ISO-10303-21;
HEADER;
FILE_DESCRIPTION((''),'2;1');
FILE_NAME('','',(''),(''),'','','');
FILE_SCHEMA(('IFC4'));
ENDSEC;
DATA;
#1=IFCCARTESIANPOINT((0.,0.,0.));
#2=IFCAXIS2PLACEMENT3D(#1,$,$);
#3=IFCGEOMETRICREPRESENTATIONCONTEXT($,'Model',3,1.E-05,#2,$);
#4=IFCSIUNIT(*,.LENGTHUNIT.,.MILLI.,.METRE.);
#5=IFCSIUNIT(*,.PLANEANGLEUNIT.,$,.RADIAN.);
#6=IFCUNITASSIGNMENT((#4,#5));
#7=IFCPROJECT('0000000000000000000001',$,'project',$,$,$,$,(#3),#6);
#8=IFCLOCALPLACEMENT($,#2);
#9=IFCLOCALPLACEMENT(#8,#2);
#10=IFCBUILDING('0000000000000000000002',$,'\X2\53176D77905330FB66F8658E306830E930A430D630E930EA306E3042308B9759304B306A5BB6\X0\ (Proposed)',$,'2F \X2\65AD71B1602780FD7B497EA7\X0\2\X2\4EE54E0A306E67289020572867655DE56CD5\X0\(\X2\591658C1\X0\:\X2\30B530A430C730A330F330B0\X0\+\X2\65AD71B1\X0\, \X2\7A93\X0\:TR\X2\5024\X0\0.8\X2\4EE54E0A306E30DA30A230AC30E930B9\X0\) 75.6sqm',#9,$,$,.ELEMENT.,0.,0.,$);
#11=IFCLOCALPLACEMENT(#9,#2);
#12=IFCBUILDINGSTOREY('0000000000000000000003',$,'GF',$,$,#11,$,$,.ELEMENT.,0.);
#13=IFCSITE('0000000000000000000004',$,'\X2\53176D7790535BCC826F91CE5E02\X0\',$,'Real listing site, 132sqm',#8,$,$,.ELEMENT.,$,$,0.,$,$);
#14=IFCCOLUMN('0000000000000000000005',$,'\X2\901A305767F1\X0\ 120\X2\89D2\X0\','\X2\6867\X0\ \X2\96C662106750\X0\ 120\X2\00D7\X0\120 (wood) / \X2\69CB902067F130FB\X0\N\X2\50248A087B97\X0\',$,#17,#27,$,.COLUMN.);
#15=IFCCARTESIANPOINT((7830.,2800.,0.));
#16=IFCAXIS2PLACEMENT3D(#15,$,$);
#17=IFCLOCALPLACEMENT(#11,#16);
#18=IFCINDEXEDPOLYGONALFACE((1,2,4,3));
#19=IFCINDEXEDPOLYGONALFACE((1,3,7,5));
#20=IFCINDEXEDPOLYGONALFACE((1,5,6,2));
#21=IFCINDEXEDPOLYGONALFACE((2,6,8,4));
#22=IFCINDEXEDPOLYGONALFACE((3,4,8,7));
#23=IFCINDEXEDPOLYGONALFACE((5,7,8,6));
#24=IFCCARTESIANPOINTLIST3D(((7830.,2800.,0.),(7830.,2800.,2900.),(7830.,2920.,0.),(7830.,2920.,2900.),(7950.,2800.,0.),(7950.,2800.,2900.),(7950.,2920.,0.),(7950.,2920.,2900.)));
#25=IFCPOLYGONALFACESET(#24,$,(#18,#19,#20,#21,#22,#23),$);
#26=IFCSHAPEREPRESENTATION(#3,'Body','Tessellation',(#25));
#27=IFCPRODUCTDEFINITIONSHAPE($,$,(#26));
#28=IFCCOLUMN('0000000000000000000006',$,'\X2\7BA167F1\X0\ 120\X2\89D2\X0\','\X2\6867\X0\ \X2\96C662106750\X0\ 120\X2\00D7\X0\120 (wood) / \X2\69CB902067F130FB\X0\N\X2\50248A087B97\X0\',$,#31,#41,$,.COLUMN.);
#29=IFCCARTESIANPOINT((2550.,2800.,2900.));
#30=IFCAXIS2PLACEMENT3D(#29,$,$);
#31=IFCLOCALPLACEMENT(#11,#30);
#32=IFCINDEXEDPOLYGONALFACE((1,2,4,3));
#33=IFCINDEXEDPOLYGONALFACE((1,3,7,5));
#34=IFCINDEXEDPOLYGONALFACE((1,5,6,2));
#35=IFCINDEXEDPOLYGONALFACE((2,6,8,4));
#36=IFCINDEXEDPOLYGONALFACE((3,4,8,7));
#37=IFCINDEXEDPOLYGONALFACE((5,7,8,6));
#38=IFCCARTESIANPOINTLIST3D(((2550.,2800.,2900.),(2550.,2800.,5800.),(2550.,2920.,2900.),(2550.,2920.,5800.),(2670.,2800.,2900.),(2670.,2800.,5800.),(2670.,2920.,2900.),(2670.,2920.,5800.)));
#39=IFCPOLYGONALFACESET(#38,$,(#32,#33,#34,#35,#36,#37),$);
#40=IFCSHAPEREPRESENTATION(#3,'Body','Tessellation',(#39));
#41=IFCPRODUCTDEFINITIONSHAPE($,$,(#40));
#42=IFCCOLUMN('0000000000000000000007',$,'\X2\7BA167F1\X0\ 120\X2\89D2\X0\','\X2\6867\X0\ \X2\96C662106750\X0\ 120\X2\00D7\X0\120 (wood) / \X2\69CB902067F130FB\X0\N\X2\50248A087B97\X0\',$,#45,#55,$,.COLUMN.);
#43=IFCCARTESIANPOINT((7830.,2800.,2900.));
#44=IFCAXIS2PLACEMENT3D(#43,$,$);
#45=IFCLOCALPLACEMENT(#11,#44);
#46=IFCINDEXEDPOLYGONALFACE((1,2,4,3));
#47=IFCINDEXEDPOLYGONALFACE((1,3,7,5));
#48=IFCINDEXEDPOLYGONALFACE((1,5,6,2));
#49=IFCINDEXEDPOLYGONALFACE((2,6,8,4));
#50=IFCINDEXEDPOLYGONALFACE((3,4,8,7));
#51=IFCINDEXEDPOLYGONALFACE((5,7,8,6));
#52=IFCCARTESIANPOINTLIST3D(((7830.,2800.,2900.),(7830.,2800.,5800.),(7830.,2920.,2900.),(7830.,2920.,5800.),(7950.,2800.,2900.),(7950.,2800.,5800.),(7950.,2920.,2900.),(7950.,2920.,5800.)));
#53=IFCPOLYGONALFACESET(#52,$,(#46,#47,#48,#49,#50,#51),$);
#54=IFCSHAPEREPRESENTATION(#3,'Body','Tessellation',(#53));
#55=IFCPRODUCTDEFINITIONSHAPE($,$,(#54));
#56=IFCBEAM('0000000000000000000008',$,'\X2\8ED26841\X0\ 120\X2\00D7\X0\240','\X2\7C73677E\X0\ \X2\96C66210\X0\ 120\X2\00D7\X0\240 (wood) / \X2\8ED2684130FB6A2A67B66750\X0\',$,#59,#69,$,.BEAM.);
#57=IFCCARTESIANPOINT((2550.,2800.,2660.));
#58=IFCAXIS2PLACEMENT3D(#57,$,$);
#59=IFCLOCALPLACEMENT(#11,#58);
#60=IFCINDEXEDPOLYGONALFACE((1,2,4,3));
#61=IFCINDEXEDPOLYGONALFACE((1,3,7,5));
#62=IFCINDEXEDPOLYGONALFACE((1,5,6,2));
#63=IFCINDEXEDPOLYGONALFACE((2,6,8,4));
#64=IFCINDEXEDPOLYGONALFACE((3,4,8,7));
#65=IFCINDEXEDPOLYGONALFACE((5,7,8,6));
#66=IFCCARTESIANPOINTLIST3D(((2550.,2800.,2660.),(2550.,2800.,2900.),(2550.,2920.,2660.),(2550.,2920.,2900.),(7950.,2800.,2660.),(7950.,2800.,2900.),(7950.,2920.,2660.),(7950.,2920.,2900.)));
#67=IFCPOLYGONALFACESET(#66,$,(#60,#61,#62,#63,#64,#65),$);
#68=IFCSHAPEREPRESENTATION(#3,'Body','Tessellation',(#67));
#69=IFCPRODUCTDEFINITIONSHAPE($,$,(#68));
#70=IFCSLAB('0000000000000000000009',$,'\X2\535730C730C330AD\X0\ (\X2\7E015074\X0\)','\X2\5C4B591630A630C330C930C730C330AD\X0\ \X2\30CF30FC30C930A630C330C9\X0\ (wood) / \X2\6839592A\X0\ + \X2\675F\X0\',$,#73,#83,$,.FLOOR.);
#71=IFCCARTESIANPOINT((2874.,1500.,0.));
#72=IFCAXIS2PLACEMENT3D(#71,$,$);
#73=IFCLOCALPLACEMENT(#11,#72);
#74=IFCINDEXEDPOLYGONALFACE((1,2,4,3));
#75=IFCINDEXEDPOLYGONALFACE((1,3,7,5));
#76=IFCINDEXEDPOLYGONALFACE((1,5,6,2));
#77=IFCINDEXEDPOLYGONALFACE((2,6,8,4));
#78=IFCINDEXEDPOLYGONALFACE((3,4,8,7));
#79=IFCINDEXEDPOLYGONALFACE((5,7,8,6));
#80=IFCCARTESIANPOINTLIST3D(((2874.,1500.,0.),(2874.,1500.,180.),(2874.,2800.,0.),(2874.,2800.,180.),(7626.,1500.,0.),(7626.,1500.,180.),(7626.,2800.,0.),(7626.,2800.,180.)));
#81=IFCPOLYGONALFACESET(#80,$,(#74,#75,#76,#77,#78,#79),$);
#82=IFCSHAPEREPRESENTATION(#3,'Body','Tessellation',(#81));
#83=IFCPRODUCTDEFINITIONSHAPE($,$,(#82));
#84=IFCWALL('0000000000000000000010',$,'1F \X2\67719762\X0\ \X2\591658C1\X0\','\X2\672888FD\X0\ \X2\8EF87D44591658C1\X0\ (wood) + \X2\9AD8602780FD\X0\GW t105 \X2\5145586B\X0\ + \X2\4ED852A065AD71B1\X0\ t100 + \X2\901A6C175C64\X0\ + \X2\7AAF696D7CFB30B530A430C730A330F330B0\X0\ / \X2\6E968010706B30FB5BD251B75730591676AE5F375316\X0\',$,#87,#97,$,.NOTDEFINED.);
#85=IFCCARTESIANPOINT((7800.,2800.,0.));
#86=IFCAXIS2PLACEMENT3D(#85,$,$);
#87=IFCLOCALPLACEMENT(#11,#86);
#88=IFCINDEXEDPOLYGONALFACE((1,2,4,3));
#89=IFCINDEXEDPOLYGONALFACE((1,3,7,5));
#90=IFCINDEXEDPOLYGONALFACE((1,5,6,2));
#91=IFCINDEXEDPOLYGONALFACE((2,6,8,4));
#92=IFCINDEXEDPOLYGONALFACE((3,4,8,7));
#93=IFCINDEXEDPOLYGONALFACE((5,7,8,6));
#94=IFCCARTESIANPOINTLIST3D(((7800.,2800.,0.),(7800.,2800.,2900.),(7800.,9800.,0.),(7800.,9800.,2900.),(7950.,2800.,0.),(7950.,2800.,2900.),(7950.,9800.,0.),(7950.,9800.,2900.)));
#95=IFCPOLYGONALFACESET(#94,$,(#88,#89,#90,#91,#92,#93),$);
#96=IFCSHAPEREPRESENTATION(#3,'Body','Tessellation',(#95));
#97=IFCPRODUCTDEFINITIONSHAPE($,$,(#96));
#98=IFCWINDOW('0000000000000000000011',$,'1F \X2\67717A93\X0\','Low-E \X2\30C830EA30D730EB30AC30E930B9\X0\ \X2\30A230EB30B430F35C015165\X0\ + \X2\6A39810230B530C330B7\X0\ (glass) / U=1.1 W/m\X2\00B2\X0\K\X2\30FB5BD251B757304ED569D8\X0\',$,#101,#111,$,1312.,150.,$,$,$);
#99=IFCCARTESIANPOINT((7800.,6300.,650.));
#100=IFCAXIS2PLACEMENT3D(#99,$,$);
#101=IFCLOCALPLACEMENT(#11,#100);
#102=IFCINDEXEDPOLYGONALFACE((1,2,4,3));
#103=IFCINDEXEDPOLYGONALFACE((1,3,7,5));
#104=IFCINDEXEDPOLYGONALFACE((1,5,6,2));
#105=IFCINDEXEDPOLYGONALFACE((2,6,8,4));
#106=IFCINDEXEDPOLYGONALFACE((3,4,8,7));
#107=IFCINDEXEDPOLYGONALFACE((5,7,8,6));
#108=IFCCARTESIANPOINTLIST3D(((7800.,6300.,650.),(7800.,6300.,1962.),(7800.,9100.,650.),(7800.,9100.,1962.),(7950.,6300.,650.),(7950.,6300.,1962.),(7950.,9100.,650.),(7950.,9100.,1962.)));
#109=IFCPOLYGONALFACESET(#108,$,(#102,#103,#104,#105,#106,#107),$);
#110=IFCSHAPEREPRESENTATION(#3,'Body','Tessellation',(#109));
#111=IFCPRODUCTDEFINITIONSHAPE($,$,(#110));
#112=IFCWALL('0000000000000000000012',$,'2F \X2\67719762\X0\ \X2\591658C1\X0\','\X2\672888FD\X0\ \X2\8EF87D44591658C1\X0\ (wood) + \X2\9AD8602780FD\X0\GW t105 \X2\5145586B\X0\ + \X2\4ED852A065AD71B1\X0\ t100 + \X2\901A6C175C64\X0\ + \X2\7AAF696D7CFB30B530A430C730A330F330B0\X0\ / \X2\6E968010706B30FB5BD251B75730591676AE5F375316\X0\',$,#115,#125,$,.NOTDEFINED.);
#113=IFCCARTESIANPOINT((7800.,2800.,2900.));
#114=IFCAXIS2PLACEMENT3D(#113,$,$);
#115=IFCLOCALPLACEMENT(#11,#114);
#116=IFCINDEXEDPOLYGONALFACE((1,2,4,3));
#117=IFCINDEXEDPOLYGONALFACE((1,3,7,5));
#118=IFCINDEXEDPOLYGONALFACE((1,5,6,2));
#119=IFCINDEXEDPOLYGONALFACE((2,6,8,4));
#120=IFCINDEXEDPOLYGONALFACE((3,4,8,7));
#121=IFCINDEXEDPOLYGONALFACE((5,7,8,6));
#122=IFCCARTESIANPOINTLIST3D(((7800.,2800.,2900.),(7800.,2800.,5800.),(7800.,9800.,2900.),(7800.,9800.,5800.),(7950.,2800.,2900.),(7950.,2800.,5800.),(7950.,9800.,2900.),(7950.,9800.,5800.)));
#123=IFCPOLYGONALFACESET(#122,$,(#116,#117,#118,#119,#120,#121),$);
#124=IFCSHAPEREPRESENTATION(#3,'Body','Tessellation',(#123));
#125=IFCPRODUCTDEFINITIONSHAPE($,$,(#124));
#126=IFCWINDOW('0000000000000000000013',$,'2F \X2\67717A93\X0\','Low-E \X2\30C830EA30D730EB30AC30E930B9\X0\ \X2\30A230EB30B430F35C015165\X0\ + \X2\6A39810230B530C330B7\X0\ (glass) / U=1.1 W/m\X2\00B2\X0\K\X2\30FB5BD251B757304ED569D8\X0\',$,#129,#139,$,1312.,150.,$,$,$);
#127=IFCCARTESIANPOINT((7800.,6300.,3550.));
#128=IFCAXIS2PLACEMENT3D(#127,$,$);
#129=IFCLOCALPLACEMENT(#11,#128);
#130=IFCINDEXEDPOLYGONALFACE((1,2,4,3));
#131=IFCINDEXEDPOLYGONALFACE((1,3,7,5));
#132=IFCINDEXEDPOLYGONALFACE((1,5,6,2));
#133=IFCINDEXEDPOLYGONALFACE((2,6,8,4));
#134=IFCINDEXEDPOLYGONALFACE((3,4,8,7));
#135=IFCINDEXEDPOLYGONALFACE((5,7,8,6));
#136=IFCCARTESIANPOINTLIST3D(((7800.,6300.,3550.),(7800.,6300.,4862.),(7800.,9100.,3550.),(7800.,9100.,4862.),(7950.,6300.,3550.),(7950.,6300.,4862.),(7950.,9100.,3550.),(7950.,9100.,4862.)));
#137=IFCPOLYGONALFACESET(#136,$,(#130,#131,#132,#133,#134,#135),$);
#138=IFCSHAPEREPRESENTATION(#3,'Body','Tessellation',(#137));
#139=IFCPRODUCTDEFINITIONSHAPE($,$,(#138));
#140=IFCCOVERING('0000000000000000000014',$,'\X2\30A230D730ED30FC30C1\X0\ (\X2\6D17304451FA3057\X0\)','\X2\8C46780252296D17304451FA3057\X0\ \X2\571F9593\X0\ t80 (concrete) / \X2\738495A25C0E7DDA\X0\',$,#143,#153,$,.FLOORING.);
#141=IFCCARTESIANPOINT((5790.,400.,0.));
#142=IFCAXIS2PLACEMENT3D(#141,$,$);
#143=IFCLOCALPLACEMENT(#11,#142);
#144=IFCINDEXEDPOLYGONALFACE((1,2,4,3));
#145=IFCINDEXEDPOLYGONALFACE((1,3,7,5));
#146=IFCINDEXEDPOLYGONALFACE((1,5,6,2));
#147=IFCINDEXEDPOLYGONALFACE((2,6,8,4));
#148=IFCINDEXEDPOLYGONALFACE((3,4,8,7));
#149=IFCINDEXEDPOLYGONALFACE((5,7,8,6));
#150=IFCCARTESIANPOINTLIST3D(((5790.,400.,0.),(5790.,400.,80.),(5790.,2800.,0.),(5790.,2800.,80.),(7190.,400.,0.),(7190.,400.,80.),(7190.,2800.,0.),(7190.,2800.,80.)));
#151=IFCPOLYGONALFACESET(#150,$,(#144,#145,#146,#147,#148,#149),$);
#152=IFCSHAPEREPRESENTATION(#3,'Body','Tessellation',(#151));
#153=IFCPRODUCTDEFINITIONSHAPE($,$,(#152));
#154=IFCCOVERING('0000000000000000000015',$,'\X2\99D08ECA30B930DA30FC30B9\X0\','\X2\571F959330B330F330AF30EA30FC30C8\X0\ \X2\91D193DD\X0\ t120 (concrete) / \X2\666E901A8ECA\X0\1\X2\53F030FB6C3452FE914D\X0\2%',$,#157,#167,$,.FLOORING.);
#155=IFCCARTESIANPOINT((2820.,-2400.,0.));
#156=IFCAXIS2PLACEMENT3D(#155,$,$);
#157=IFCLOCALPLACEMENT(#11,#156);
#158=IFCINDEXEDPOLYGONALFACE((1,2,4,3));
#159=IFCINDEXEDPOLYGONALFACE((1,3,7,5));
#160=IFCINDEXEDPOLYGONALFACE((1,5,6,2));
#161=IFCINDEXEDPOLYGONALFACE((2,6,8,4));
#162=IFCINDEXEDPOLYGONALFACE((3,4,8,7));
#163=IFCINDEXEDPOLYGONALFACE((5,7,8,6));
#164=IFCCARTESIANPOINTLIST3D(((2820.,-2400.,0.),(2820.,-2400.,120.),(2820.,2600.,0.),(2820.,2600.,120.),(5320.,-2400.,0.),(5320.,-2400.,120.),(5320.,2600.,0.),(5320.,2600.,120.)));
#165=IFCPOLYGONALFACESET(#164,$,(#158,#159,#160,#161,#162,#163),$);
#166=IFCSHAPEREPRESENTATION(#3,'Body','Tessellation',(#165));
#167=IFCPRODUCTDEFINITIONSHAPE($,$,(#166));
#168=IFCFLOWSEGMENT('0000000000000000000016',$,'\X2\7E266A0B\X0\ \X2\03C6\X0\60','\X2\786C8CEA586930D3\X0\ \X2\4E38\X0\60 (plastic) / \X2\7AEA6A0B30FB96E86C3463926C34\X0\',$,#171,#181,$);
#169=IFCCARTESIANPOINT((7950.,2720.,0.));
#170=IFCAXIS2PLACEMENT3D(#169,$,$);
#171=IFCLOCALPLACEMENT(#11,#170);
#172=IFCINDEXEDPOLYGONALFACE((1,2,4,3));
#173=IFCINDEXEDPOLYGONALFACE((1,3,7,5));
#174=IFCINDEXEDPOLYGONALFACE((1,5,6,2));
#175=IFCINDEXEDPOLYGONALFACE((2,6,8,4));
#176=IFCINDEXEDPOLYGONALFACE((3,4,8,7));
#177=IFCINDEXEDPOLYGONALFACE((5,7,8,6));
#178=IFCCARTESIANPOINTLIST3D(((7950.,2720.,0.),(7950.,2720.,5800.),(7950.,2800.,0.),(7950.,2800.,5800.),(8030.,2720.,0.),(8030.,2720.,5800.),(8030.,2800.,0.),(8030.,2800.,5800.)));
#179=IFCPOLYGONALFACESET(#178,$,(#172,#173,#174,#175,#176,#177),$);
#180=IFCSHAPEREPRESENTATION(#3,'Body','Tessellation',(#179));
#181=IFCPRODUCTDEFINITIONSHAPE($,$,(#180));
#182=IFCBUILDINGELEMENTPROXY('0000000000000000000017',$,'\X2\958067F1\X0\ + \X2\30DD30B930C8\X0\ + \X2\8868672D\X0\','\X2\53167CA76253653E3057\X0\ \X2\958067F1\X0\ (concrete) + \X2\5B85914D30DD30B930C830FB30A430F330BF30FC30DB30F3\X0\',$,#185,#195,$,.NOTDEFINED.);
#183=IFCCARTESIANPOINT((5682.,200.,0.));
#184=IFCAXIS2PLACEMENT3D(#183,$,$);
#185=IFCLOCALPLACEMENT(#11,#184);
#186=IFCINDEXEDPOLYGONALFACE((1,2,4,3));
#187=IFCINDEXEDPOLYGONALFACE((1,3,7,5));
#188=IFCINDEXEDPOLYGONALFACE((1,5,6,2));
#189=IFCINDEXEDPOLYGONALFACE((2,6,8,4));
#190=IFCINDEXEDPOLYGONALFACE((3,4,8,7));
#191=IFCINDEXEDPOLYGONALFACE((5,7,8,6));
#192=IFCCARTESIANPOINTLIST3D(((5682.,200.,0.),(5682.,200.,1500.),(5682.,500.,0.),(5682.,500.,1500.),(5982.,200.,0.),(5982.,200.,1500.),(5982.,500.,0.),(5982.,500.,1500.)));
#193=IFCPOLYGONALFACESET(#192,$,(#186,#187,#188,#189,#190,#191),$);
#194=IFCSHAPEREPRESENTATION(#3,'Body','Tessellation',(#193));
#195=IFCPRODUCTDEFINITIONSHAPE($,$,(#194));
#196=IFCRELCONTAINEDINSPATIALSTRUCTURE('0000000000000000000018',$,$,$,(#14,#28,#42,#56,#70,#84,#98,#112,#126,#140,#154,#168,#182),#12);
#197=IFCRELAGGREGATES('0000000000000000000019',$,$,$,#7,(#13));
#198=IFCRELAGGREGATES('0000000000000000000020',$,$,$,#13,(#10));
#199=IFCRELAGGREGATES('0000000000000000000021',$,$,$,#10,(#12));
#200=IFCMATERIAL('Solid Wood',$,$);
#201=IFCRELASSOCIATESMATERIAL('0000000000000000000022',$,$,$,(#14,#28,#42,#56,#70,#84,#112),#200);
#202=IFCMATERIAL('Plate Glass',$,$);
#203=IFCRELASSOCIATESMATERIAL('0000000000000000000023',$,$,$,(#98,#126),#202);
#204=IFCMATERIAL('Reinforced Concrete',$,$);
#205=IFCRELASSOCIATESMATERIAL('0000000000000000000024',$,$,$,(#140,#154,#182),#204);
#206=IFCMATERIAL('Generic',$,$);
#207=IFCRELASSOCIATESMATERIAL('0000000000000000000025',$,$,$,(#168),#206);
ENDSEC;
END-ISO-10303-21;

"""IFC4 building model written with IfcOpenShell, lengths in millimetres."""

from ifc_helpers import new_model, si_unit, frame, frame_2d, origin, place, context, project, spatial, rectangle, extrude, material, element, fill, save


model = new_model("IFC4")

# Units and contexts
model_context = context("Model", 3, precision=1e-05, world=origin())
ifc_project = project(units=[si_unit("LENGTHUNIT", "METRE", prefix="MILLI"), si_unit("PLANEANGLEUNIT", "RADIAN")], contexts=[model_context])

# Site, building, storey
site_placement = place(None, origin())
site = spatial("IfcSite", under=ifc_project, at=site_placement, Name="北海道富良野市", ObjectType="Real listing site, 132sqm", CompositionType="ELEMENT", RefElevation=0.0)
building_placement = place(site_placement, origin())
building = spatial("IfcBuilding", under=site, at=building_placement, Name="北海道・書斎とライブラリのある静かな家 (Proposed)", ObjectType="2F 断熱性能等级2以上の木造在来工法(外壁:サイディング+断熱, 窓:TR値0.8以上のペアガラス) 75.6sqm", CompositionType="ELEMENT", ElevationOfRefHeight=0.0, ElevationOfTerrain=0.0)
storey_placement = place(building_placement, origin())
storey = spatial("IfcBuildingStorey", under=building, at=storey_placement, Name="GF", CompositionType="ELEMENT", Elevation=0.0)

# Columns
ifc_material_1 = material(Name="Solid Wood")
column_1_placement = place(storey_placement, frame((7830.0, 2800.0, 0.0)))
element("IfcColumn", 1, at=column_1_placement, inside=storey, material=ifc_material_1, Name="通し柱 120角", Description="桧 集成材 120×120 (wood) / 構造柱・N値計算", PredefinedType="COLUMN", context=model_context, shape_type="SweptSolid", body=[
    extrude(rectangle(XDim=120.0, YDim=120.0, at=frame_2d((60.0, 60.0))), frame((7830.0, 2800.0, 0.0)), (0.0, 0.0, 1.0), 2900.0),
])
column_2_placement = place(storey_placement, frame((2550.0, 2800.0, 2900.0)))
element("IfcColumn", 2, at=column_2_placement, inside=storey, material=ifc_material_1, Name="管柱 120角", Description="桧 集成材 120×120 (wood) / 構造柱・N値計算", PredefinedType="COLUMN", context=model_context, shape_type="SweptSolid", body=[
    extrude(rectangle(XDim=120.0, YDim=120.0, at=frame_2d((60.0, 60.0))), frame((2550.0, 2800.0, 2900.0)), (0.0, 0.0, 1.0), 2900.0),
])
column_3_placement = place(storey_placement, frame((7830.0, 2800.0, 2900.0)))
element("IfcColumn", 3, at=column_3_placement, inside=storey, material=ifc_material_1, Name="管柱 120角", Description="桧 集成材 120×120 (wood) / 構造柱・N値計算", PredefinedType="COLUMN", context=model_context, shape_type="SweptSolid", body=[
    extrude(rectangle(XDim=120.0, YDim=120.0, at=frame_2d((60.0, 60.0))), frame((7830.0, 2800.0, 2900.0)), (0.0, 0.0, 1.0), 2900.0),
])

# Beam
beam_1_placement = place(storey_placement, frame((2550.0, 2800.0, 2660.0)))
element("IfcBeam", 4, at=beam_1_placement, inside=storey, material=ifc_material_1, Name="軒桁 120×240", Description="米松 集成 120×240 (wood) / 軒桁・横架材", PredefinedType="BEAM", context=model_context, shape_type="SweptSolid", body=[
    extrude(rectangle(XDim=5400.0, YDim=120.0, at=frame_2d((2700.0, 60.0))), frame((2550.0, 2800.0, 2660.0)), (0.0, 0.0, 1.0), 240.0),
])

# Slab
slab_placement = place(storey_placement, frame((2874.0, 1500.0, 0.0)))
element("IfcSlab", 5, at=slab_placement, inside=storey, material=ifc_material_1, Name="南デッキ (縁側)", Description="屋外ウッドデッキ ハードウッド (wood) / 根太 + 束", PredefinedType="FLOOR", context=model_context, shape_type="SweptSolid", body=[
    extrude(rectangle(XDim=4752.0, YDim=1300.0, at=frame_2d((2376.0, 650.0))), frame((2874.0, 1500.0, 0.0)), (0.0, 0.0, 1.0), 180.0),
])

# Walls, openings, windows
wall_1_placement = place(storey_placement, frame((7800.0, 2800.0, 0.0)))
wall_1 = element("IfcWall", 6, at=wall_1_placement, inside=storey, material=ifc_material_1, Name="1F 東面 外壁", Description="木製 軸組外壁 (wood) + 高性能GW t105 充填 + 付加断熱 t100 + 通気層 + 窯業系サイディング / 準耐火・寒冷地外皮強化", PredefinedType="NOTDEFINED", context=model_context, shape_type="SweptSolid", body=[
    extrude(rectangle(XDim=150.0, YDim=7000.0, at=frame_2d((75.0, 3500.0))), frame((7800.0, 2800.0, 0.0)), (0.0, 0.0, 1.0), 2900.0),
])
opening_1_placement = place(storey_placement, frame((7800.0, 6300.0, 650.0)))
opening_1 = element("IfcOpeningElement", 7, at=opening_1_placement, cuts=wall_1, PredefinedType="NOTDEFINED", context=model_context, shape_type="SweptSolid", body=[
    extrude(rectangle(XDim=150.0, YDim=2800.0, at=frame_2d((75.0, 1400.0))), frame((7800.0, 6300.0, 650.0)), (0.0, 0.0, 1.0), 1312.0),
])
ifc_material_2 = material(Name="Plate Glass")
window_1_placement = place(storey_placement, frame((7800.0, 6300.0, 650.0)))
window_1 = element("IfcWindow", 8, at=window_1_placement, inside=storey, material=ifc_material_2, Name="1F 東窓", Description="Low-E トリプルガラス アルゴン封入 + 樹脂サッシ (glass) / U=1.1 W/m²K・寒冷地仕様", OverallHeight=1312.0, OverallWidth=150.0, context=model_context, shape_type="SweptSolid", body=[
    extrude(rectangle(XDim=150.0, YDim=2800.0, at=frame_2d((75.0, 1400.0))), frame((7800.0, 6300.0, 650.0)), (0.0, 0.0, 1.0), 1312.0),
])
fill(opening_1, window_1)
wall_2_placement = place(storey_placement, frame((7800.0, 2800.0, 2900.0)))
wall_2 = element("IfcWall", 9, at=wall_2_placement, inside=storey, material=ifc_material_1, Name="2F 東面 外壁", Description="木製 軸組外壁 (wood) + 高性能GW t105 充填 + 付加断熱 t100 + 通気層 + 窯業系サイディング / 準耐火・寒冷地外皮強化", PredefinedType="NOTDEFINED", context=model_context, shape_type="SweptSolid", body=[
    extrude(rectangle(XDim=150.0, YDim=7000.0, at=frame_2d((75.0, 3500.0))), frame((7800.0, 2800.0, 2900.0)), (0.0, 0.0, 1.0), 2900.0),
])
opening_2_placement = place(storey_placement, frame((7800.0, 6300.0, 3550.0)))
opening_2 = element("IfcOpeningElement", 10, at=opening_2_placement, cuts=wall_2, PredefinedType="NOTDEFINED", context=model_context, shape_type="SweptSolid", body=[
    extrude(rectangle(XDim=150.0, YDim=2800.0, at=frame_2d((75.0, 1400.0))), frame((7800.0, 6300.0, 3550.0)), (0.0, 0.0, 1.0), 1312.0),
])
window_2_placement = place(storey_placement, frame((7800.0, 6300.0, 3550.0)))
window_2 = element("IfcWindow", 11, at=window_2_placement, inside=storey, material=ifc_material_2, Name="2F 東窓", Description="Low-E トリプルガラス アルゴン封入 + 樹脂サッシ (glass) / U=1.1 W/m²K・寒冷地仕様", OverallHeight=1312.0, OverallWidth=150.0, context=model_context, shape_type="SweptSolid", body=[
    extrude(rectangle(XDim=150.0, YDim=2800.0, at=frame_2d((75.0, 1400.0))), frame((7800.0, 6300.0, 3550.0)), (0.0, 0.0, 1.0), 1312.0),
])
fill(opening_2, window_2)

# Coverings
ifc_material_3 = material(Name="Reinforced Concrete")
covering_1_placement = place(storey_placement, frame((5790.0, 400.0, 0.0)))
element("IfcCovering", 12, at=covering_1_placement, inside=storey, material=ifc_material_3, Name="アプローチ (洗い出し)", Description="豆砂利洗い出し 土間 t80 (concrete) / 玄関導線", PredefinedType="FLOORING", context=model_context, shape_type="SweptSolid", body=[
    extrude(rectangle(XDim=1400.0, YDim=2400.0, at=frame_2d((700.0, 1200.0))), frame((5790.0, 400.0, 0.0)), (0.0, 0.0, 1.0), 80.0),
])
covering_2_placement = place(storey_placement, frame((2820.0, -2400.0, 0.0)))
element("IfcCovering", 13, at=covering_2_placement, inside=storey, material=ifc_material_3, Name="駐車スペース", Description="土間コンクリート 金鏝 t120 (concrete) / 普通車1台・水勾配2%", PredefinedType="FLOORING", context=model_context, shape_type="SweptSolid", body=[
    extrude(rectangle(XDim=2500.0, YDim=5000.0, at=frame_2d((1250.0, 2500.0))), frame((2820.0, -2400.0, 0.0)), (0.0, 0.0, 1.0), 120.0),
])

# Flow segment
ifc_material_4 = material(Name="Generic")
flow_segment_placement = place(storey_placement, frame((7950.0, 2720.0, 0.0)))
element("IfcFlowSegment", 14, at=flow_segment_placement, inside=storey, material=ifc_material_4, Name="縦樋 φ60", Description="硬質塩ビ 丸60 (plastic) / 竪樋・雨水排水", context=model_context, shape_type="SweptSolid", body=[
    extrude(rectangle(XDim=80.0, YDim=80.0, at=frame_2d((40.0, 40.0))), frame((7950.0, 2720.0, 0.0)), (0.0, 0.0, 1.0), 5800.0),
])

# Building element proxy
proxy_placement = place(storey_placement, frame((5682.0, 200.0, 0.0)))
element("IfcBuildingElementProxy", 15, at=proxy_placement, inside=storey, material=ifc_material_3, Name="門柱 + ポスト + 表札", Description="化粧打放し 門柱 (concrete) + 宅配ポスト・インターホン", PredefinedType="NOTDEFINED", context=model_context, shape_type="SweptSolid", body=[
    extrude(rectangle(XDim=300.0, YDim=300.0, at=frame_2d((150.0, 150.0))), frame((5682.0, 200.0, 0.0)), (0.0, 0.0, 1.0), 1500.0),
])

save(model, "model.ifc")
